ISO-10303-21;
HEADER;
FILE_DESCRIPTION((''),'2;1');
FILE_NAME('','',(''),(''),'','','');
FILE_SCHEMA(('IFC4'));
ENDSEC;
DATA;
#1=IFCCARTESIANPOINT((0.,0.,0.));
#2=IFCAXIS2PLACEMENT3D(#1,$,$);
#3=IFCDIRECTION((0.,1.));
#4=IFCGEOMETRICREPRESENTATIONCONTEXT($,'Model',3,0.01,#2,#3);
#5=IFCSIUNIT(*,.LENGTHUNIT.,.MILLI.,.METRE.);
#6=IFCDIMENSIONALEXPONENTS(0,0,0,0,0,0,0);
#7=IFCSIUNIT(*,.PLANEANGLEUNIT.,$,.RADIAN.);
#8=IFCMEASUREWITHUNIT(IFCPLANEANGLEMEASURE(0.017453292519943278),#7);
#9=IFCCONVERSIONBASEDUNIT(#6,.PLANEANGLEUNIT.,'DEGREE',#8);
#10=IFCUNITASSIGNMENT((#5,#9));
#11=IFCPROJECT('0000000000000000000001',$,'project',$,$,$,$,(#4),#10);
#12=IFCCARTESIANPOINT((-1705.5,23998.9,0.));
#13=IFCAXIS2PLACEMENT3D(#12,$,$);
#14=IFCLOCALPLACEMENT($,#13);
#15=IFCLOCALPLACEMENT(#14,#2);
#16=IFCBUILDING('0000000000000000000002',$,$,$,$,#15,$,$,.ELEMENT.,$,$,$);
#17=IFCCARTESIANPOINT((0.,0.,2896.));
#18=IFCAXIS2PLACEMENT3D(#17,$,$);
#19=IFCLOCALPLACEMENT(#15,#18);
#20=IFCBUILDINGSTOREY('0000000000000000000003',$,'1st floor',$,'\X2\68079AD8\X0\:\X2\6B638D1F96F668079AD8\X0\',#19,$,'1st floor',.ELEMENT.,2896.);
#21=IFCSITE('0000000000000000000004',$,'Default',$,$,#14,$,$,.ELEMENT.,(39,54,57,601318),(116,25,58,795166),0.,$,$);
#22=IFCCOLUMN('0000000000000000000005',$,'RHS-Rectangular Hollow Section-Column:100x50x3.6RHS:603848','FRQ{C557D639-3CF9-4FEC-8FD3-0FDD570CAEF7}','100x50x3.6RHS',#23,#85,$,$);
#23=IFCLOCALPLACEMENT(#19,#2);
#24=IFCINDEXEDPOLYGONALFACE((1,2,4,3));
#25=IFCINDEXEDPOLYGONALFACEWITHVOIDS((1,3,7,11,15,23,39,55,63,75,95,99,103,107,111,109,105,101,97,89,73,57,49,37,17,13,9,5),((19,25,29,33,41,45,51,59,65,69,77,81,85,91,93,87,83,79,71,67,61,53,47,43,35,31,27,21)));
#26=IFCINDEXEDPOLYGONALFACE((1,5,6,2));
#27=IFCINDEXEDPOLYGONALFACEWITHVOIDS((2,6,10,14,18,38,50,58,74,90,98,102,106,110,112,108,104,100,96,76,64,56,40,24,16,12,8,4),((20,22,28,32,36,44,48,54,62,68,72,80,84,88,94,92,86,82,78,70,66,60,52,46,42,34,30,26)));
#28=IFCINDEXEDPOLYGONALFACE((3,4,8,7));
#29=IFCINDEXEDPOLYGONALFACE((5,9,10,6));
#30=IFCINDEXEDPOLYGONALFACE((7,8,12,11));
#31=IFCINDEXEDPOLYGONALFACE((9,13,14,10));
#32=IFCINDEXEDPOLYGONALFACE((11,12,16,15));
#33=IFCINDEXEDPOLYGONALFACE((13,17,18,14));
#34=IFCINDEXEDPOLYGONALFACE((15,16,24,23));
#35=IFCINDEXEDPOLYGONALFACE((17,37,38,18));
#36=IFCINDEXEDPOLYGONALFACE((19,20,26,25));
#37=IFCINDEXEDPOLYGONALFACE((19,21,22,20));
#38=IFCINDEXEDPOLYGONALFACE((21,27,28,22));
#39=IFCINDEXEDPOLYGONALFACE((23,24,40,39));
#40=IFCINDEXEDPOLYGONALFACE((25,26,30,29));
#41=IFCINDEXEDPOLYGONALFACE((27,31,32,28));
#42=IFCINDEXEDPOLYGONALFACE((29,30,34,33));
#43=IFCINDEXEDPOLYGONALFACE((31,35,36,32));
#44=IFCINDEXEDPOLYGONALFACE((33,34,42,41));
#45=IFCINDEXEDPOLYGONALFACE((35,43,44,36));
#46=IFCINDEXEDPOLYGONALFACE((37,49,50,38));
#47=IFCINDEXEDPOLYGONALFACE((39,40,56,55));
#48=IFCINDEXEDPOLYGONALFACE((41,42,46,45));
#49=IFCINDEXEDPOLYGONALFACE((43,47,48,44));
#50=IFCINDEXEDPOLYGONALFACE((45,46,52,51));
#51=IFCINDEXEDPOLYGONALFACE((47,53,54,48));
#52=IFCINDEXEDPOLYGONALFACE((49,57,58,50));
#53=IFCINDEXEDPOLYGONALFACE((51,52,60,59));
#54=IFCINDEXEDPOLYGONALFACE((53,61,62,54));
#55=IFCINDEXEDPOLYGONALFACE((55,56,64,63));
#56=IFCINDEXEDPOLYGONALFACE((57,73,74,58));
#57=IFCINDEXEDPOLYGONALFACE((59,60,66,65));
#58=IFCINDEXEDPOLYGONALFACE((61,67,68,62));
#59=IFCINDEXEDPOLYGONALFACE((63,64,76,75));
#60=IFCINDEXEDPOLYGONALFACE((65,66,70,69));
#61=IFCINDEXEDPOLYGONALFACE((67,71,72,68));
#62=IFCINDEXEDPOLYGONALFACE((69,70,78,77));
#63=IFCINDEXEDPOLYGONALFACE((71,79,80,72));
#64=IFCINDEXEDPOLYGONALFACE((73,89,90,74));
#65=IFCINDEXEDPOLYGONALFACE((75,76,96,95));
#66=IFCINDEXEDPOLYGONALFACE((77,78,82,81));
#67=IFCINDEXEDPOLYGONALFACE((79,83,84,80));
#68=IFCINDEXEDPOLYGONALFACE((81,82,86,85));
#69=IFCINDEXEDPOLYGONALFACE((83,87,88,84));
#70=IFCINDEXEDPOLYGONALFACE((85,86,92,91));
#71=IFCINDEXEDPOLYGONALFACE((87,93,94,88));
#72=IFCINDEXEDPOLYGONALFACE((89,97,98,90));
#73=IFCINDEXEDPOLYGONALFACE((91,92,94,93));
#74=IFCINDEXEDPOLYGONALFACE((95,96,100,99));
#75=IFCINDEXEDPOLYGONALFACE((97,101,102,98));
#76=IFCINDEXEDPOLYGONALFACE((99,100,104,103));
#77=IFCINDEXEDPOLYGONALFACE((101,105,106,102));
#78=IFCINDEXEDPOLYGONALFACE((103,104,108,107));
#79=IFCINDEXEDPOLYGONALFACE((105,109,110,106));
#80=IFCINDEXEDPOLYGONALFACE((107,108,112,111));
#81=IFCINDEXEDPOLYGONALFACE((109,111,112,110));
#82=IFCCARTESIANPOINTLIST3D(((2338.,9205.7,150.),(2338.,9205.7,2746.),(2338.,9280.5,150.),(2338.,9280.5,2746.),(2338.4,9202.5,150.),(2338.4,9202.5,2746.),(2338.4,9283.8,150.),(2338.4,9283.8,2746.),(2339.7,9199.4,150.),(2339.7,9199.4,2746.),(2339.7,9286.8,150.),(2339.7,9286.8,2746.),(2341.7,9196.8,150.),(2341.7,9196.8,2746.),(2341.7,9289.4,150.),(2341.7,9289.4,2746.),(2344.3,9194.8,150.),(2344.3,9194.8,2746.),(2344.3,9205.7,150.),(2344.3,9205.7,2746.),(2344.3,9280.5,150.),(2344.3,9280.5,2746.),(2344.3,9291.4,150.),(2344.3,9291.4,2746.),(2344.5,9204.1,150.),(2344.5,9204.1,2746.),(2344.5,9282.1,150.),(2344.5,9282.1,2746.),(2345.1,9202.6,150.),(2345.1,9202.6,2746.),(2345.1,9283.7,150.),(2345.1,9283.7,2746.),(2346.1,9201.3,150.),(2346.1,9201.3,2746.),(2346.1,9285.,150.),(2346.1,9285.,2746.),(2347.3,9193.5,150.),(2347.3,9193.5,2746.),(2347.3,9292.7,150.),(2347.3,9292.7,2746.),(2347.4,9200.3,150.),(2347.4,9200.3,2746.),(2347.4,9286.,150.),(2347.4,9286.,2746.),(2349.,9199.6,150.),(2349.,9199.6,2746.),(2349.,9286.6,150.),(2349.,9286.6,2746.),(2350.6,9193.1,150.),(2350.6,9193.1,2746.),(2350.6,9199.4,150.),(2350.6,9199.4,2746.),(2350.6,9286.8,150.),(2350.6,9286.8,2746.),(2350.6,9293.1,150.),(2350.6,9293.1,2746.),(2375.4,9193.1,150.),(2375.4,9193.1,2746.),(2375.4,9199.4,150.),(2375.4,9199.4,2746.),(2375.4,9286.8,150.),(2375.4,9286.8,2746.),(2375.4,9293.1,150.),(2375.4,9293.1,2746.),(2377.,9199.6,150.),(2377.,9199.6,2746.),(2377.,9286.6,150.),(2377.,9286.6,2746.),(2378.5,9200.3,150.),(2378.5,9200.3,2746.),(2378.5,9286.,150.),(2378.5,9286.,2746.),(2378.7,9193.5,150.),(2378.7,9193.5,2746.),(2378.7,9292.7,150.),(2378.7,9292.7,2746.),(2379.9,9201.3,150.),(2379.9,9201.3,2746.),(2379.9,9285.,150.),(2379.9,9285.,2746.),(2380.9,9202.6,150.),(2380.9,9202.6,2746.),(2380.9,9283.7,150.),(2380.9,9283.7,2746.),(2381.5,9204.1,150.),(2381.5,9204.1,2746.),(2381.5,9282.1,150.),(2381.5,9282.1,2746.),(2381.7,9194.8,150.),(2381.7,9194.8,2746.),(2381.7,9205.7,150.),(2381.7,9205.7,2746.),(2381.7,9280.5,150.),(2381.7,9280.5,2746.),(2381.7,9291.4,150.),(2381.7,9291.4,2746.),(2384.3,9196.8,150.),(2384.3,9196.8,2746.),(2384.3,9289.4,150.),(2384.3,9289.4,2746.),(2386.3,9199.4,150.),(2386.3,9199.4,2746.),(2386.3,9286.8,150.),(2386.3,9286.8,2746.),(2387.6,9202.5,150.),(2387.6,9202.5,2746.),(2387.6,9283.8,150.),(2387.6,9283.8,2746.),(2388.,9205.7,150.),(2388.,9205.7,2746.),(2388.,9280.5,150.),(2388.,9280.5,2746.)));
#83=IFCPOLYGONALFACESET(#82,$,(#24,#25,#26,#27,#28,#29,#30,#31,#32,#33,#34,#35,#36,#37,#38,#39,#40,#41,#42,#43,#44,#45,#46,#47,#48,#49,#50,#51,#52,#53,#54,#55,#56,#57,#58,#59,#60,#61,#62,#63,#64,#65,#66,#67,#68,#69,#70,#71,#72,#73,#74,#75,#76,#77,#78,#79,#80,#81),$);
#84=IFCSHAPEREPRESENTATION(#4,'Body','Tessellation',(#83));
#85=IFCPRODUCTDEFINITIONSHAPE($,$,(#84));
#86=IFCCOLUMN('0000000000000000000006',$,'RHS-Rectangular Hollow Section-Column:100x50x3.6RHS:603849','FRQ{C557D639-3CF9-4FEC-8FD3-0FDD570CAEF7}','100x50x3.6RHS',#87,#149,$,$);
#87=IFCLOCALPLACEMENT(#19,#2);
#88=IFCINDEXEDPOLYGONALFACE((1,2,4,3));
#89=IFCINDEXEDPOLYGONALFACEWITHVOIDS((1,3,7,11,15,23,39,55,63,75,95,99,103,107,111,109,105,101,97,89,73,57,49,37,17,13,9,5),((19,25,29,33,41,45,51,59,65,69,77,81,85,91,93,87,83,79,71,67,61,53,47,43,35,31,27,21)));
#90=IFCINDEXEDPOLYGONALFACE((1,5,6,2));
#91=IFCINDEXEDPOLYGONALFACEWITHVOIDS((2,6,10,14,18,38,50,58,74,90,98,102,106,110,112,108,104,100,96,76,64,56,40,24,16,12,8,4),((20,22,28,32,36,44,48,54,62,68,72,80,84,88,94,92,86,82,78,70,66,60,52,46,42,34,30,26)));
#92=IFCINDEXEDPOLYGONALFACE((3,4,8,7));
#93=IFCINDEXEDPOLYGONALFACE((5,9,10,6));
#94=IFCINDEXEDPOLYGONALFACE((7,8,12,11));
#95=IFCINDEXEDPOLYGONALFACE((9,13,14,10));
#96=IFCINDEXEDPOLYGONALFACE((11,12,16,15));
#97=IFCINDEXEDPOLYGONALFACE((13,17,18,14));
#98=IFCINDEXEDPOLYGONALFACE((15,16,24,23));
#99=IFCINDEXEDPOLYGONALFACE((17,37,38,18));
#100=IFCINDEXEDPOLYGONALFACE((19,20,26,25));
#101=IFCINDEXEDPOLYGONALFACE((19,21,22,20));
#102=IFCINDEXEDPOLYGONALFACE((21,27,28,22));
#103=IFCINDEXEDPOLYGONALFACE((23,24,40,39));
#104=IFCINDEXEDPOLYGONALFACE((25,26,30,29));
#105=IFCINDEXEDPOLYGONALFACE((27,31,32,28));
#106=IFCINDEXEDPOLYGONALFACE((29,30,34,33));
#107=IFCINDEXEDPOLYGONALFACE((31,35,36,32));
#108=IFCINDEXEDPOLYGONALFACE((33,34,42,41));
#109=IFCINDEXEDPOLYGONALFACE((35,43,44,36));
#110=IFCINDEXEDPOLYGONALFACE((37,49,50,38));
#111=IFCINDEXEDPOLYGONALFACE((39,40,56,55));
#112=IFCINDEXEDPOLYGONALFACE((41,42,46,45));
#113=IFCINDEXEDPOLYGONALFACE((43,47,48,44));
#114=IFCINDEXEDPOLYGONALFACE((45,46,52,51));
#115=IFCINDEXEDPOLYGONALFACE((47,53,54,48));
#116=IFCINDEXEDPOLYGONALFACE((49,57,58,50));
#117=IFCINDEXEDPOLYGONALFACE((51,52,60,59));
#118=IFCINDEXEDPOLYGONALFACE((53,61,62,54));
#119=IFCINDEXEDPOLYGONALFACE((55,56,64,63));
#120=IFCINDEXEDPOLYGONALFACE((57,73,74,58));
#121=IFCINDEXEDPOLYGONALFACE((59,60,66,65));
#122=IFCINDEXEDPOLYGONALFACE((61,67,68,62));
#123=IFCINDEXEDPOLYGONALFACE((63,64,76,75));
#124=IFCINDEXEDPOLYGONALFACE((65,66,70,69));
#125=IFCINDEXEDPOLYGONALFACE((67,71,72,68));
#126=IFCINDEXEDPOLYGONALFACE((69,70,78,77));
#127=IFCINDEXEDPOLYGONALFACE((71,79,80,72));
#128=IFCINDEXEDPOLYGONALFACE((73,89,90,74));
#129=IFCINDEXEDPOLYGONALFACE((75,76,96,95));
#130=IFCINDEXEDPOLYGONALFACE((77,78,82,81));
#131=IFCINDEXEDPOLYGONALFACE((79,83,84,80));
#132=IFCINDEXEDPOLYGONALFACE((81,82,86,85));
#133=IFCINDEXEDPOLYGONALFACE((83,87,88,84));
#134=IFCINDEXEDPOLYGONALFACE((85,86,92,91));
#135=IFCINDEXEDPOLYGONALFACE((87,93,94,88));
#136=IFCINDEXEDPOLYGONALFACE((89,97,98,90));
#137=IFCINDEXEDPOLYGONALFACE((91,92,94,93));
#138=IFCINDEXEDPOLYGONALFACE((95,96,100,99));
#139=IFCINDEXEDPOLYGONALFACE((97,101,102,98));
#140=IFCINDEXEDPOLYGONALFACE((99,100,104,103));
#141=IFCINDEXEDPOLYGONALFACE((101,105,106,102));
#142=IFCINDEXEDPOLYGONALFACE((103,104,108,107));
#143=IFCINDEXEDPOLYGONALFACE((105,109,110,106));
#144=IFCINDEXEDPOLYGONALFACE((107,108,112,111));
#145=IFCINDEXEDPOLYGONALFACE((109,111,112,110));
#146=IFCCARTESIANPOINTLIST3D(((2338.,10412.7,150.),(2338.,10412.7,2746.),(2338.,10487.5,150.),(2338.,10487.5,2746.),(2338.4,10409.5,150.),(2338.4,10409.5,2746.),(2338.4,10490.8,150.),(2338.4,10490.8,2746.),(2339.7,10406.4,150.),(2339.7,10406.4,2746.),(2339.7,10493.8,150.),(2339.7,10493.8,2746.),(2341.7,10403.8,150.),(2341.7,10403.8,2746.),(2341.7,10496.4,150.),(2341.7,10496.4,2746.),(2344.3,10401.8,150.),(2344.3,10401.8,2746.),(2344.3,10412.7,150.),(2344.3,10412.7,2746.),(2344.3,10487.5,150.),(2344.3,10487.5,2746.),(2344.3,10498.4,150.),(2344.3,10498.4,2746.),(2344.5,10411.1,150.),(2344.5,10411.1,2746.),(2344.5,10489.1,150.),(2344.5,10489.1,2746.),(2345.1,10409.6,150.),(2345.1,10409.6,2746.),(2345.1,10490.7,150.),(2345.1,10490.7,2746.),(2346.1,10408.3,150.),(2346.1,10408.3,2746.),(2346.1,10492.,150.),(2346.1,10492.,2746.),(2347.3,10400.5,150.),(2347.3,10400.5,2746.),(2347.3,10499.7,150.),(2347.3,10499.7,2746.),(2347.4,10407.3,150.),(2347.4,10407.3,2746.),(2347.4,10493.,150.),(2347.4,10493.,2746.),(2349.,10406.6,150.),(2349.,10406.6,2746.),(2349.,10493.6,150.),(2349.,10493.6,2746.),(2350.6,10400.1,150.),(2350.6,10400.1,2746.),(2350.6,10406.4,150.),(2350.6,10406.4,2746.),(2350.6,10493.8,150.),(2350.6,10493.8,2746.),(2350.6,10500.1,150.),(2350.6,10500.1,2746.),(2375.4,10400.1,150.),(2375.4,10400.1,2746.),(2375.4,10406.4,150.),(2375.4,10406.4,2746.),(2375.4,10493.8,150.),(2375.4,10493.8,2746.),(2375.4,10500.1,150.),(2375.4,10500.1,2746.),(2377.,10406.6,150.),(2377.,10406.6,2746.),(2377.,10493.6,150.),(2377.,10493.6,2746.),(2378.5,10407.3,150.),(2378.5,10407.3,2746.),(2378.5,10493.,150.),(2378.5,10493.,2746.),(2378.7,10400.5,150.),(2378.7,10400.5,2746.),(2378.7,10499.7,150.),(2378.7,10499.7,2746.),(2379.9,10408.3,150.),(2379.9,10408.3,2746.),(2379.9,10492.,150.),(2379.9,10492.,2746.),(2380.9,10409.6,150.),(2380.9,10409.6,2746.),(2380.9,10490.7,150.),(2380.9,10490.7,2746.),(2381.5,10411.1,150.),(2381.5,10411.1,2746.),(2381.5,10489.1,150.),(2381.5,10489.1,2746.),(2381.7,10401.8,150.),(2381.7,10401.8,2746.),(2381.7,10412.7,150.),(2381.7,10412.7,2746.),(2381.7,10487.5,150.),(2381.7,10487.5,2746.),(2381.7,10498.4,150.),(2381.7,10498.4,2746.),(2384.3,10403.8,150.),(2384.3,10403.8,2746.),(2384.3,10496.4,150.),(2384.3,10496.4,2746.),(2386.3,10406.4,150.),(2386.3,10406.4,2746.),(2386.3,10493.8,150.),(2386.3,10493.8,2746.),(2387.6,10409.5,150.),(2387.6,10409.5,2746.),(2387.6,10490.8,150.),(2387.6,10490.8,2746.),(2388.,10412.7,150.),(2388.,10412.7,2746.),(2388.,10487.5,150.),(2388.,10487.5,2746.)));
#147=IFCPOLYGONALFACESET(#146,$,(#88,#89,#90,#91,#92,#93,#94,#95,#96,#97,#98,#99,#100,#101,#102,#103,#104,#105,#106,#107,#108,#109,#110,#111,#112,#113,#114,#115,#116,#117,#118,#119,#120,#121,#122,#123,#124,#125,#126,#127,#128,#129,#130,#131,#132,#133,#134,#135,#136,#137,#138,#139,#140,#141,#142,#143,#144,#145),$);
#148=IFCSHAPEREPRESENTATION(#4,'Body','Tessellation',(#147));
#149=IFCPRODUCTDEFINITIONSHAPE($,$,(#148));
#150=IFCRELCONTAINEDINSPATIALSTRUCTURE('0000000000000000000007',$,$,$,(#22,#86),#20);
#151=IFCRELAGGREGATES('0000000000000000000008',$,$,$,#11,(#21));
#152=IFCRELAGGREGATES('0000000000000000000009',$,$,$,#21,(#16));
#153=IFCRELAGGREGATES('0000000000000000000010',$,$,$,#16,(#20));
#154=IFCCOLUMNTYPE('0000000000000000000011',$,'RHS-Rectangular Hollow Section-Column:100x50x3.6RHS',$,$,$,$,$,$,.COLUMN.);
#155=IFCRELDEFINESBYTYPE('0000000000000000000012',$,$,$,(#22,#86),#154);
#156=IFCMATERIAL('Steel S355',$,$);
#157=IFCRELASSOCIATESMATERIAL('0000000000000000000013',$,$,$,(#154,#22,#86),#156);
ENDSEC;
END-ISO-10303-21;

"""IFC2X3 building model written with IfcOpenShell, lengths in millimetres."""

from ifc_helpers import new_model, entity, si_unit, converted_unit, direction, frame, origin, origin_2d, place, context, project, spatial, hollow_rectangle, extrude, clip, halfspace, material, type_object, element, save


model = new_model("IFC2X3")

# Units and contexts
model_context = context("Model", 3, precision=0.01, world=origin(), true_north=direction((0.0, 1.0)))
ifc_project = project(units=[si_unit("LENGTHUNIT", "METRE", prefix="MILLI"), converted_unit("PLANEANGLEUNIT", "DEGREE", entity("IfcPlaneAngleMeasure", 0.017453292519943278), si_unit("PLANEANGLEUNIT", "RADIAN"), dimensions=[0, 0, 0, 0, 0, 0, 0])], contexts=[model_context])

# Site, building, storey
site_placement = place(None, frame((-1705.5, 23998.9, 0.0)))
site = spatial("IfcSite", under=ifc_project, at=site_placement, Name="Default", CompositionType="ELEMENT", RefLatitude=(39, 54, 57, 601318), RefLongitude=(116, 25, 58, 795166), RefElevation=0.0)
building_placement = place(site_placement, origin())
building = spatial("IfcBuilding", under=site, at=building_placement, CompositionType="ELEMENT")
storey_placement = place(building_placement, frame((0.0, 0.0, 2896.0)))
storey = spatial("IfcBuildingStorey", under=building, at=storey_placement, Name="1st floor", ObjectType="标高:正负零标高", LongName="1st floor", CompositionType="ELEMENT", Elevation=2896.0)

# Shared definitions
ifc_material_1 = material(Name="Steel S355")
column_type = type_object("IfcColumnType", Name="RHS-Rectangular Hollow Section-Column:100x50x3.6RHS", PredefinedType="COLUMN", material=ifc_material_1)

# Columns
column_1_placement = place(storey_placement, frame((2363.0, 9243.1, 2746.0), z_axis=(0.0, 0.0, 1.0), x_axis=(-1.0, 0.0, 0.0)))
element("IfcColumn", 1, at=column_1_placement, inside=storey, type_object=column_type, material=ifc_material_1, Name="RHS-Rectangular Hollow Section-Column:100x50x3.6RHS:603848", Description="FRQ{C557D639-3CF9-4FEC-8FD3-0FDD570CAEF7}", ObjectType="100x50x3.6RHS", context=model_context, shape_type="Clipping", body=[
    clip(extrude(hollow_rectangle(XDim=50.0, YDim=100.0, WallThickness=6.3, InnerFilletRadius=6.3, OuterFilletRadius=12.6, at=origin_2d()), origin(), (0.0, 0.0, -1.0), 2651.9), halfspace(frame((2363.0, 9243.1, -2596.0), z_axis=(0.0, 0.0, 1.0), x_axis=(-1.0, 0.0, 0.0)), True)),
])
column_2_placement = place(storey_placement, frame((2363.0, 10450.1, 2746.0), z_axis=(0.0, 0.0, 1.0), x_axis=(-1.0, 0.0, 0.0)))
element("IfcColumn", 2, at=column_2_placement, inside=storey, type_object=column_type, material=ifc_material_1, Name="RHS-Rectangular Hollow Section-Column:100x50x3.6RHS:603849", Description="FRQ{C557D639-3CF9-4FEC-8FD3-0FDD570CAEF7}", ObjectType="100x50x3.6RHS", context=model_context, shape_type="Clipping", body=[
    clip(extrude(hollow_rectangle(XDim=50.0, YDim=100.0, WallThickness=6.3, InnerFilletRadius=6.3, OuterFilletRadius=12.6, at=origin_2d()), origin(), (0.0, 0.0, -1.0), 2651.9), halfspace(frame((2363.0, 10450.1, -2596.0), z_axis=(0.0, 0.0, 1.0), x_axis=(-1.0, 0.0, 0.0)), True)),
])

save(model, "model.ifc")
